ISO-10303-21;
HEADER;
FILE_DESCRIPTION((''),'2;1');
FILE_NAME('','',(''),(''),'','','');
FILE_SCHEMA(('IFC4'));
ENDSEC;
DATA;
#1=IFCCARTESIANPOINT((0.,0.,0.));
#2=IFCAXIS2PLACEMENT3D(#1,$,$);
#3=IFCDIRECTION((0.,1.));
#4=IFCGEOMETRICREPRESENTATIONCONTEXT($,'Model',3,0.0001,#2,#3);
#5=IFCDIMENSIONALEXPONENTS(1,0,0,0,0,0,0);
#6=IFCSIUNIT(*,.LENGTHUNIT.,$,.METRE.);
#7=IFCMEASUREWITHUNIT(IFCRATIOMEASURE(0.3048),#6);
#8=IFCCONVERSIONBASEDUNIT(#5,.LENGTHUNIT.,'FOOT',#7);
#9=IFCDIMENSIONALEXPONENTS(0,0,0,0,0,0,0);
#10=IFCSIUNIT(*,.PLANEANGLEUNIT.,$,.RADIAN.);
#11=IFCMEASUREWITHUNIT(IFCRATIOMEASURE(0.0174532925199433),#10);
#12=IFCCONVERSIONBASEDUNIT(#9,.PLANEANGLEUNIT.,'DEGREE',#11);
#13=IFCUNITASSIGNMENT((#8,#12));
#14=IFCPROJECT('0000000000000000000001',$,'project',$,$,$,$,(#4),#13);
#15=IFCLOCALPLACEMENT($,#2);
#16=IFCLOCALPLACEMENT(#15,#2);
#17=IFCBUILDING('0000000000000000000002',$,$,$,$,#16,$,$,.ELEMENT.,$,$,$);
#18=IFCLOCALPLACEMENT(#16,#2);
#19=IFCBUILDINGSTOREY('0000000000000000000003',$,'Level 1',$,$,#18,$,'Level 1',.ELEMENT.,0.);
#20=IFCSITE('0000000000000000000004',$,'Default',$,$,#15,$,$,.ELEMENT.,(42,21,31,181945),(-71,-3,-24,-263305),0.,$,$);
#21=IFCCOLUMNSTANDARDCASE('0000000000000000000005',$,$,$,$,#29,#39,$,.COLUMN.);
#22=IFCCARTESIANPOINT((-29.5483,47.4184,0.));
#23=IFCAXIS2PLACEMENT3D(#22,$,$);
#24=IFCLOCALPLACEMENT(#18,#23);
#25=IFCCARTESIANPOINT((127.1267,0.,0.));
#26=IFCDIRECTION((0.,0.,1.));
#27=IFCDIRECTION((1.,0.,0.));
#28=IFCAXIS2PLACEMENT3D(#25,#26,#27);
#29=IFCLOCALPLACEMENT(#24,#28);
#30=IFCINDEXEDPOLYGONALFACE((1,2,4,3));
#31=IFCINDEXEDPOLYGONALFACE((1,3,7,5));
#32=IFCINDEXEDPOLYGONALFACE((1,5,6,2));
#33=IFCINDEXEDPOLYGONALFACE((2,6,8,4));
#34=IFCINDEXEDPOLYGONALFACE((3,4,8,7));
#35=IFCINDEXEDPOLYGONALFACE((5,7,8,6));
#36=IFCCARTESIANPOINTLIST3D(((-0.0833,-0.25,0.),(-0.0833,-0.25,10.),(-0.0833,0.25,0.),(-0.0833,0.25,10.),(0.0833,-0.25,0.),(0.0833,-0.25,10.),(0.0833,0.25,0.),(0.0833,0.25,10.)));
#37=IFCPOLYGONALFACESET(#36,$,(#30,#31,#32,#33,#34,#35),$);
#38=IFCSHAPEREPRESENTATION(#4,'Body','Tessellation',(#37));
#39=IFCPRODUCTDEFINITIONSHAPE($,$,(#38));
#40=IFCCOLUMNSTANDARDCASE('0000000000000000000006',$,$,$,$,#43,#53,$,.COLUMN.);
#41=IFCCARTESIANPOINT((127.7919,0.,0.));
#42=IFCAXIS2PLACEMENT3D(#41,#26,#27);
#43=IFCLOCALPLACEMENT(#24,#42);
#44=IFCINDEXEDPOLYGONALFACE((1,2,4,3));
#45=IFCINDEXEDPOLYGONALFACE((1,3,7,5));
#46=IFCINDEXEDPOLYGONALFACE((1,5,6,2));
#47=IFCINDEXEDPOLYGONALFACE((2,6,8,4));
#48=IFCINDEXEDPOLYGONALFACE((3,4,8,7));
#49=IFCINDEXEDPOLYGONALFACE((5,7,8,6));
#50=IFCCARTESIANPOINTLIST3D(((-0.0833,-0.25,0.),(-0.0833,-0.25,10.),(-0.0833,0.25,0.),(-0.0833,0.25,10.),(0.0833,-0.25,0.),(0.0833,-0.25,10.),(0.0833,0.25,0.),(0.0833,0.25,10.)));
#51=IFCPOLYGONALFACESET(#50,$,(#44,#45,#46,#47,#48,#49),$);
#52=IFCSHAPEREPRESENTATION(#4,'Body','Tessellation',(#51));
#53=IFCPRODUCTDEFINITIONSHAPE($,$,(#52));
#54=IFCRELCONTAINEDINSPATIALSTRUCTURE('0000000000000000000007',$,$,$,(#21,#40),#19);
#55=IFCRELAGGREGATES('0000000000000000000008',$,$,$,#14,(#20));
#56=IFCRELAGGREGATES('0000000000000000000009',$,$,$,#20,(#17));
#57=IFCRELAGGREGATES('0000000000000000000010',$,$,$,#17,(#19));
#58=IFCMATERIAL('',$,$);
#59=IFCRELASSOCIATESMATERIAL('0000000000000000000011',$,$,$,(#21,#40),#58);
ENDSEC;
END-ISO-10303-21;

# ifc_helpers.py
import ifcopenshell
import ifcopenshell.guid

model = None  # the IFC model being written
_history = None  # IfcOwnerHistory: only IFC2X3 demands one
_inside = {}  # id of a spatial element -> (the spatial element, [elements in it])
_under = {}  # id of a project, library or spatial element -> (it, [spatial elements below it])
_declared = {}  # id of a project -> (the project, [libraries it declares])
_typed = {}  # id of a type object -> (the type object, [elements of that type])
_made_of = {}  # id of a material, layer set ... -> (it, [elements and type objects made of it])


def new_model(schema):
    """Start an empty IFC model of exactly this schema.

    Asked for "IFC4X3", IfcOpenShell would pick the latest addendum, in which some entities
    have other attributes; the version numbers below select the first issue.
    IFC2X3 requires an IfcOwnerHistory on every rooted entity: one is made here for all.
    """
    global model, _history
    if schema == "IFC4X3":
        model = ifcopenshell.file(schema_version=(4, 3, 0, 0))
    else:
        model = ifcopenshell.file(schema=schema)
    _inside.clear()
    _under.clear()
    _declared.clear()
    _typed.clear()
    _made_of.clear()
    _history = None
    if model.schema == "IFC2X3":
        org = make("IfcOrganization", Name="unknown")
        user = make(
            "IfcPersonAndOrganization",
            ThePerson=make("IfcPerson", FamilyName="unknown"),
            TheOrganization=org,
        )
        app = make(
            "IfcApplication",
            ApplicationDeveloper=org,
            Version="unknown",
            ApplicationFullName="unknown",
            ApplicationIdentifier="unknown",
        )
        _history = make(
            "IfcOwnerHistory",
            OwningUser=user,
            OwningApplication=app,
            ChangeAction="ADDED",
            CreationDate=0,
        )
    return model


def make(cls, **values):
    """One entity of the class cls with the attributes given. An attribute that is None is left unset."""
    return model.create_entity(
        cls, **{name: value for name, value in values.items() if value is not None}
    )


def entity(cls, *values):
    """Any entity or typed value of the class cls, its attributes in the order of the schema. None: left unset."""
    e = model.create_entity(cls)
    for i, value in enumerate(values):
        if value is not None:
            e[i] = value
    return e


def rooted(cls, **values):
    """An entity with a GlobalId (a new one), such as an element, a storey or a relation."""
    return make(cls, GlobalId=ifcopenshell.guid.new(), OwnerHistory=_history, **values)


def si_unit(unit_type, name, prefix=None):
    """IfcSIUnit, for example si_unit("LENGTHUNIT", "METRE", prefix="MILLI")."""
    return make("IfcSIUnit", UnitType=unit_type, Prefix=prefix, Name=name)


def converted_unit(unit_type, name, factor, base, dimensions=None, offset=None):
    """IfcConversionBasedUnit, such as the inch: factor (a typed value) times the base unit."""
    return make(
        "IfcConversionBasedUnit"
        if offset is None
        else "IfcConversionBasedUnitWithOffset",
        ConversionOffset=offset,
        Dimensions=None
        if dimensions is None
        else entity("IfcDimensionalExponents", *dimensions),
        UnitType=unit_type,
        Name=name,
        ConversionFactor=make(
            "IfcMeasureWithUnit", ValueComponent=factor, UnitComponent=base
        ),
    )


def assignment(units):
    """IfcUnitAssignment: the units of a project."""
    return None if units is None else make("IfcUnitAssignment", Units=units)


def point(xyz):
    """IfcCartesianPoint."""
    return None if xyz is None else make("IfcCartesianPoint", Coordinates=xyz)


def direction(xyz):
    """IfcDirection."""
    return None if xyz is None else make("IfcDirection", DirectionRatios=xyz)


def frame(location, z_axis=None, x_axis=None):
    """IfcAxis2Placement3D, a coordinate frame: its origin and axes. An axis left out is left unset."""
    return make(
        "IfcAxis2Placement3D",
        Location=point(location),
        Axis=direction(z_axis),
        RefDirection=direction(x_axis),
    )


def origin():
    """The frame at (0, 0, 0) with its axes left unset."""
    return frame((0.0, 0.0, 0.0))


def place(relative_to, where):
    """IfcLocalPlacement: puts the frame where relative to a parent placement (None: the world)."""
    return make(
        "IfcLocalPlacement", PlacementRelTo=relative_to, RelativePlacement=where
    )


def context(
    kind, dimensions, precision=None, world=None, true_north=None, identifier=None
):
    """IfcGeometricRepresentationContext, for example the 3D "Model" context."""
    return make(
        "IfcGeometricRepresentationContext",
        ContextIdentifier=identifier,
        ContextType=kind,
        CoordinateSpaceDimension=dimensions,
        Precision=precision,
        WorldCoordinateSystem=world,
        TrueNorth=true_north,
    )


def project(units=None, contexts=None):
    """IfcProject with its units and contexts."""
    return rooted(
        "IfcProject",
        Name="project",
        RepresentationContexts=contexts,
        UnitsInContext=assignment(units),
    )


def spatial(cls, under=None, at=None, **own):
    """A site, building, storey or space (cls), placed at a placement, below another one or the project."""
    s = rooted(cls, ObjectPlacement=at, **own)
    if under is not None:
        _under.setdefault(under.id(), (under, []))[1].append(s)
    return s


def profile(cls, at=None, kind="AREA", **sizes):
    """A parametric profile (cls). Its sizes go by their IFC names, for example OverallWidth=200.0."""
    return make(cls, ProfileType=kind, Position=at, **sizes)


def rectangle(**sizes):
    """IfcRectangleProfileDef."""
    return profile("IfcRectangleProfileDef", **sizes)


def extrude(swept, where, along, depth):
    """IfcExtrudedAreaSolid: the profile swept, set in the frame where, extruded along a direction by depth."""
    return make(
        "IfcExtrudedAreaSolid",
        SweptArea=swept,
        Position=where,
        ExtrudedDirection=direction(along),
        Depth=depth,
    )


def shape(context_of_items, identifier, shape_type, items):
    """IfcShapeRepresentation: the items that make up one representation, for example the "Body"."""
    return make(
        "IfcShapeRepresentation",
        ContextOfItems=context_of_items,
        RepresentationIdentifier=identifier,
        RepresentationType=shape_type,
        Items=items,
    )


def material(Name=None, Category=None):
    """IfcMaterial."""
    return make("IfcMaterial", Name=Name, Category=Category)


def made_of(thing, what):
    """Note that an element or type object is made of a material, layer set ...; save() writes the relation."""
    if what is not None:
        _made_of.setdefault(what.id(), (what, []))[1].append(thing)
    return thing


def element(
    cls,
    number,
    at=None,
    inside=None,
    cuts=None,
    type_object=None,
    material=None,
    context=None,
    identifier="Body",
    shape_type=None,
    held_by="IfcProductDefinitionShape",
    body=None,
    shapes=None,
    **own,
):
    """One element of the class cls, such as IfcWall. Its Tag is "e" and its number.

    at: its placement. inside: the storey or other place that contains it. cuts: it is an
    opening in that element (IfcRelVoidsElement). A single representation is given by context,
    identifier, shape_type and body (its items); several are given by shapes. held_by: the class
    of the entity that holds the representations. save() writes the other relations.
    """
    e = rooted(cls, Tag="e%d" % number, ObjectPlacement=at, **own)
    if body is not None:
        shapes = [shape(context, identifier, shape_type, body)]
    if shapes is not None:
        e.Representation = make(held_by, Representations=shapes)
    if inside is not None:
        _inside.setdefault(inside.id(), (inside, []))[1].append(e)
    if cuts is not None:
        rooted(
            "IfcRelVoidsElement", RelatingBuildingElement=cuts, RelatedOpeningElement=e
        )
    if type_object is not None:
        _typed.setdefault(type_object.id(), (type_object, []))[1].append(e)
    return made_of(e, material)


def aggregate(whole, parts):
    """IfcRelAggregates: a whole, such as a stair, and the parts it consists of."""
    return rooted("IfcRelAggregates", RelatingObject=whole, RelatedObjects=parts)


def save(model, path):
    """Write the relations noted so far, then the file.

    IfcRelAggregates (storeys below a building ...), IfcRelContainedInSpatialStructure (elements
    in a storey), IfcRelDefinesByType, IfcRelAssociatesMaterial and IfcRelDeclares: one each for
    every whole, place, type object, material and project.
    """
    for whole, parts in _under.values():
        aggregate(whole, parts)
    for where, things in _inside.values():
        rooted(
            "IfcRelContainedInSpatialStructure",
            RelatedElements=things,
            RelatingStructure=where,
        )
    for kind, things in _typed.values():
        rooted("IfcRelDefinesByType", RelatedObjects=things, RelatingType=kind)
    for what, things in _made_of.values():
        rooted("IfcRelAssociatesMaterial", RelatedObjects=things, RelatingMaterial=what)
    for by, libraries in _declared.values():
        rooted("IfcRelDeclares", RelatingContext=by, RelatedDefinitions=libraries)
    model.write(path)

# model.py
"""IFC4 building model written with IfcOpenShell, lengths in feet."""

from ifc_helpers import new_model, entity, si_unit, converted_unit, direction, frame, origin, place, context, project, spatial, rectangle, extrude, material, element, save


model = new_model("IFC4")

# Units and contexts
model_context = context("Model", 3, precision=0.0001, world=origin(), true_north=direction((0.0, 1.0)))
ifc_project = project(units=[converted_unit("LENGTHUNIT", "FOOT", entity("IfcRatioMeasure", 0.3048), si_unit("LENGTHUNIT", "METRE"), dimensions=[1, 0, 0, 0, 0, 0, 0]), converted_unit("PLANEANGLEUNIT", "DEGREE", entity("IfcRatioMeasure", 0.0174532925199433), si_unit("PLANEANGLEUNIT", "RADIAN"), dimensions=[0, 0, 0, 0, 0, 0, 0])], contexts=[model_context])

# Site, building, storey
site_placement = place(None, origin())
site = spatial("IfcSite", under=ifc_project, at=site_placement, Name="Default", CompositionType="ELEMENT", RefLatitude=(42, 21, 31, 181945), RefLongitude=(-71, -3, -24, -263305), RefElevation=0.0)
building_placement = place(site_placement, origin())
building = spatial("IfcBuilding", under=site, at=building_placement, CompositionType="ELEMENT")
storey_placement = place(building_placement, origin())
storey = spatial("IfcBuildingStorey", under=building, at=storey_placement, Name="Level 1", LongName="Level 1", CompositionType="ELEMENT", Elevation=0.0)

# Columns
ifc_material_1 = material(Name="")
placement = place(storey_placement, frame((-29.5483, 47.4184, 0.0)))
for number, where, z_axis, x_axis in (
    (1, (127.1267, 0.0, 0.0), (0.0, 0.0, 1.0), (1.0, 0.0, 0.0)),
    (2, (127.7919, 0.0, 0.0), (0.0, 0.0, 1.0), (1.0, 0.0, 0.0)),
):
    element("IfcColumnStandardCase", number, at=place(placement, frame(where, z_axis=z_axis, x_axis=x_axis)), inside=storey, material=ifc_material_1, PredefinedType="COLUMN", context=model_context, shape_type="SweptSolid", body=[
        extrude(rectangle(XDim=0.1667, YDim=0.5), origin(), (0.0, 0.0, 1.0), 10.0),
    ])

save(model, "model.ifc")
